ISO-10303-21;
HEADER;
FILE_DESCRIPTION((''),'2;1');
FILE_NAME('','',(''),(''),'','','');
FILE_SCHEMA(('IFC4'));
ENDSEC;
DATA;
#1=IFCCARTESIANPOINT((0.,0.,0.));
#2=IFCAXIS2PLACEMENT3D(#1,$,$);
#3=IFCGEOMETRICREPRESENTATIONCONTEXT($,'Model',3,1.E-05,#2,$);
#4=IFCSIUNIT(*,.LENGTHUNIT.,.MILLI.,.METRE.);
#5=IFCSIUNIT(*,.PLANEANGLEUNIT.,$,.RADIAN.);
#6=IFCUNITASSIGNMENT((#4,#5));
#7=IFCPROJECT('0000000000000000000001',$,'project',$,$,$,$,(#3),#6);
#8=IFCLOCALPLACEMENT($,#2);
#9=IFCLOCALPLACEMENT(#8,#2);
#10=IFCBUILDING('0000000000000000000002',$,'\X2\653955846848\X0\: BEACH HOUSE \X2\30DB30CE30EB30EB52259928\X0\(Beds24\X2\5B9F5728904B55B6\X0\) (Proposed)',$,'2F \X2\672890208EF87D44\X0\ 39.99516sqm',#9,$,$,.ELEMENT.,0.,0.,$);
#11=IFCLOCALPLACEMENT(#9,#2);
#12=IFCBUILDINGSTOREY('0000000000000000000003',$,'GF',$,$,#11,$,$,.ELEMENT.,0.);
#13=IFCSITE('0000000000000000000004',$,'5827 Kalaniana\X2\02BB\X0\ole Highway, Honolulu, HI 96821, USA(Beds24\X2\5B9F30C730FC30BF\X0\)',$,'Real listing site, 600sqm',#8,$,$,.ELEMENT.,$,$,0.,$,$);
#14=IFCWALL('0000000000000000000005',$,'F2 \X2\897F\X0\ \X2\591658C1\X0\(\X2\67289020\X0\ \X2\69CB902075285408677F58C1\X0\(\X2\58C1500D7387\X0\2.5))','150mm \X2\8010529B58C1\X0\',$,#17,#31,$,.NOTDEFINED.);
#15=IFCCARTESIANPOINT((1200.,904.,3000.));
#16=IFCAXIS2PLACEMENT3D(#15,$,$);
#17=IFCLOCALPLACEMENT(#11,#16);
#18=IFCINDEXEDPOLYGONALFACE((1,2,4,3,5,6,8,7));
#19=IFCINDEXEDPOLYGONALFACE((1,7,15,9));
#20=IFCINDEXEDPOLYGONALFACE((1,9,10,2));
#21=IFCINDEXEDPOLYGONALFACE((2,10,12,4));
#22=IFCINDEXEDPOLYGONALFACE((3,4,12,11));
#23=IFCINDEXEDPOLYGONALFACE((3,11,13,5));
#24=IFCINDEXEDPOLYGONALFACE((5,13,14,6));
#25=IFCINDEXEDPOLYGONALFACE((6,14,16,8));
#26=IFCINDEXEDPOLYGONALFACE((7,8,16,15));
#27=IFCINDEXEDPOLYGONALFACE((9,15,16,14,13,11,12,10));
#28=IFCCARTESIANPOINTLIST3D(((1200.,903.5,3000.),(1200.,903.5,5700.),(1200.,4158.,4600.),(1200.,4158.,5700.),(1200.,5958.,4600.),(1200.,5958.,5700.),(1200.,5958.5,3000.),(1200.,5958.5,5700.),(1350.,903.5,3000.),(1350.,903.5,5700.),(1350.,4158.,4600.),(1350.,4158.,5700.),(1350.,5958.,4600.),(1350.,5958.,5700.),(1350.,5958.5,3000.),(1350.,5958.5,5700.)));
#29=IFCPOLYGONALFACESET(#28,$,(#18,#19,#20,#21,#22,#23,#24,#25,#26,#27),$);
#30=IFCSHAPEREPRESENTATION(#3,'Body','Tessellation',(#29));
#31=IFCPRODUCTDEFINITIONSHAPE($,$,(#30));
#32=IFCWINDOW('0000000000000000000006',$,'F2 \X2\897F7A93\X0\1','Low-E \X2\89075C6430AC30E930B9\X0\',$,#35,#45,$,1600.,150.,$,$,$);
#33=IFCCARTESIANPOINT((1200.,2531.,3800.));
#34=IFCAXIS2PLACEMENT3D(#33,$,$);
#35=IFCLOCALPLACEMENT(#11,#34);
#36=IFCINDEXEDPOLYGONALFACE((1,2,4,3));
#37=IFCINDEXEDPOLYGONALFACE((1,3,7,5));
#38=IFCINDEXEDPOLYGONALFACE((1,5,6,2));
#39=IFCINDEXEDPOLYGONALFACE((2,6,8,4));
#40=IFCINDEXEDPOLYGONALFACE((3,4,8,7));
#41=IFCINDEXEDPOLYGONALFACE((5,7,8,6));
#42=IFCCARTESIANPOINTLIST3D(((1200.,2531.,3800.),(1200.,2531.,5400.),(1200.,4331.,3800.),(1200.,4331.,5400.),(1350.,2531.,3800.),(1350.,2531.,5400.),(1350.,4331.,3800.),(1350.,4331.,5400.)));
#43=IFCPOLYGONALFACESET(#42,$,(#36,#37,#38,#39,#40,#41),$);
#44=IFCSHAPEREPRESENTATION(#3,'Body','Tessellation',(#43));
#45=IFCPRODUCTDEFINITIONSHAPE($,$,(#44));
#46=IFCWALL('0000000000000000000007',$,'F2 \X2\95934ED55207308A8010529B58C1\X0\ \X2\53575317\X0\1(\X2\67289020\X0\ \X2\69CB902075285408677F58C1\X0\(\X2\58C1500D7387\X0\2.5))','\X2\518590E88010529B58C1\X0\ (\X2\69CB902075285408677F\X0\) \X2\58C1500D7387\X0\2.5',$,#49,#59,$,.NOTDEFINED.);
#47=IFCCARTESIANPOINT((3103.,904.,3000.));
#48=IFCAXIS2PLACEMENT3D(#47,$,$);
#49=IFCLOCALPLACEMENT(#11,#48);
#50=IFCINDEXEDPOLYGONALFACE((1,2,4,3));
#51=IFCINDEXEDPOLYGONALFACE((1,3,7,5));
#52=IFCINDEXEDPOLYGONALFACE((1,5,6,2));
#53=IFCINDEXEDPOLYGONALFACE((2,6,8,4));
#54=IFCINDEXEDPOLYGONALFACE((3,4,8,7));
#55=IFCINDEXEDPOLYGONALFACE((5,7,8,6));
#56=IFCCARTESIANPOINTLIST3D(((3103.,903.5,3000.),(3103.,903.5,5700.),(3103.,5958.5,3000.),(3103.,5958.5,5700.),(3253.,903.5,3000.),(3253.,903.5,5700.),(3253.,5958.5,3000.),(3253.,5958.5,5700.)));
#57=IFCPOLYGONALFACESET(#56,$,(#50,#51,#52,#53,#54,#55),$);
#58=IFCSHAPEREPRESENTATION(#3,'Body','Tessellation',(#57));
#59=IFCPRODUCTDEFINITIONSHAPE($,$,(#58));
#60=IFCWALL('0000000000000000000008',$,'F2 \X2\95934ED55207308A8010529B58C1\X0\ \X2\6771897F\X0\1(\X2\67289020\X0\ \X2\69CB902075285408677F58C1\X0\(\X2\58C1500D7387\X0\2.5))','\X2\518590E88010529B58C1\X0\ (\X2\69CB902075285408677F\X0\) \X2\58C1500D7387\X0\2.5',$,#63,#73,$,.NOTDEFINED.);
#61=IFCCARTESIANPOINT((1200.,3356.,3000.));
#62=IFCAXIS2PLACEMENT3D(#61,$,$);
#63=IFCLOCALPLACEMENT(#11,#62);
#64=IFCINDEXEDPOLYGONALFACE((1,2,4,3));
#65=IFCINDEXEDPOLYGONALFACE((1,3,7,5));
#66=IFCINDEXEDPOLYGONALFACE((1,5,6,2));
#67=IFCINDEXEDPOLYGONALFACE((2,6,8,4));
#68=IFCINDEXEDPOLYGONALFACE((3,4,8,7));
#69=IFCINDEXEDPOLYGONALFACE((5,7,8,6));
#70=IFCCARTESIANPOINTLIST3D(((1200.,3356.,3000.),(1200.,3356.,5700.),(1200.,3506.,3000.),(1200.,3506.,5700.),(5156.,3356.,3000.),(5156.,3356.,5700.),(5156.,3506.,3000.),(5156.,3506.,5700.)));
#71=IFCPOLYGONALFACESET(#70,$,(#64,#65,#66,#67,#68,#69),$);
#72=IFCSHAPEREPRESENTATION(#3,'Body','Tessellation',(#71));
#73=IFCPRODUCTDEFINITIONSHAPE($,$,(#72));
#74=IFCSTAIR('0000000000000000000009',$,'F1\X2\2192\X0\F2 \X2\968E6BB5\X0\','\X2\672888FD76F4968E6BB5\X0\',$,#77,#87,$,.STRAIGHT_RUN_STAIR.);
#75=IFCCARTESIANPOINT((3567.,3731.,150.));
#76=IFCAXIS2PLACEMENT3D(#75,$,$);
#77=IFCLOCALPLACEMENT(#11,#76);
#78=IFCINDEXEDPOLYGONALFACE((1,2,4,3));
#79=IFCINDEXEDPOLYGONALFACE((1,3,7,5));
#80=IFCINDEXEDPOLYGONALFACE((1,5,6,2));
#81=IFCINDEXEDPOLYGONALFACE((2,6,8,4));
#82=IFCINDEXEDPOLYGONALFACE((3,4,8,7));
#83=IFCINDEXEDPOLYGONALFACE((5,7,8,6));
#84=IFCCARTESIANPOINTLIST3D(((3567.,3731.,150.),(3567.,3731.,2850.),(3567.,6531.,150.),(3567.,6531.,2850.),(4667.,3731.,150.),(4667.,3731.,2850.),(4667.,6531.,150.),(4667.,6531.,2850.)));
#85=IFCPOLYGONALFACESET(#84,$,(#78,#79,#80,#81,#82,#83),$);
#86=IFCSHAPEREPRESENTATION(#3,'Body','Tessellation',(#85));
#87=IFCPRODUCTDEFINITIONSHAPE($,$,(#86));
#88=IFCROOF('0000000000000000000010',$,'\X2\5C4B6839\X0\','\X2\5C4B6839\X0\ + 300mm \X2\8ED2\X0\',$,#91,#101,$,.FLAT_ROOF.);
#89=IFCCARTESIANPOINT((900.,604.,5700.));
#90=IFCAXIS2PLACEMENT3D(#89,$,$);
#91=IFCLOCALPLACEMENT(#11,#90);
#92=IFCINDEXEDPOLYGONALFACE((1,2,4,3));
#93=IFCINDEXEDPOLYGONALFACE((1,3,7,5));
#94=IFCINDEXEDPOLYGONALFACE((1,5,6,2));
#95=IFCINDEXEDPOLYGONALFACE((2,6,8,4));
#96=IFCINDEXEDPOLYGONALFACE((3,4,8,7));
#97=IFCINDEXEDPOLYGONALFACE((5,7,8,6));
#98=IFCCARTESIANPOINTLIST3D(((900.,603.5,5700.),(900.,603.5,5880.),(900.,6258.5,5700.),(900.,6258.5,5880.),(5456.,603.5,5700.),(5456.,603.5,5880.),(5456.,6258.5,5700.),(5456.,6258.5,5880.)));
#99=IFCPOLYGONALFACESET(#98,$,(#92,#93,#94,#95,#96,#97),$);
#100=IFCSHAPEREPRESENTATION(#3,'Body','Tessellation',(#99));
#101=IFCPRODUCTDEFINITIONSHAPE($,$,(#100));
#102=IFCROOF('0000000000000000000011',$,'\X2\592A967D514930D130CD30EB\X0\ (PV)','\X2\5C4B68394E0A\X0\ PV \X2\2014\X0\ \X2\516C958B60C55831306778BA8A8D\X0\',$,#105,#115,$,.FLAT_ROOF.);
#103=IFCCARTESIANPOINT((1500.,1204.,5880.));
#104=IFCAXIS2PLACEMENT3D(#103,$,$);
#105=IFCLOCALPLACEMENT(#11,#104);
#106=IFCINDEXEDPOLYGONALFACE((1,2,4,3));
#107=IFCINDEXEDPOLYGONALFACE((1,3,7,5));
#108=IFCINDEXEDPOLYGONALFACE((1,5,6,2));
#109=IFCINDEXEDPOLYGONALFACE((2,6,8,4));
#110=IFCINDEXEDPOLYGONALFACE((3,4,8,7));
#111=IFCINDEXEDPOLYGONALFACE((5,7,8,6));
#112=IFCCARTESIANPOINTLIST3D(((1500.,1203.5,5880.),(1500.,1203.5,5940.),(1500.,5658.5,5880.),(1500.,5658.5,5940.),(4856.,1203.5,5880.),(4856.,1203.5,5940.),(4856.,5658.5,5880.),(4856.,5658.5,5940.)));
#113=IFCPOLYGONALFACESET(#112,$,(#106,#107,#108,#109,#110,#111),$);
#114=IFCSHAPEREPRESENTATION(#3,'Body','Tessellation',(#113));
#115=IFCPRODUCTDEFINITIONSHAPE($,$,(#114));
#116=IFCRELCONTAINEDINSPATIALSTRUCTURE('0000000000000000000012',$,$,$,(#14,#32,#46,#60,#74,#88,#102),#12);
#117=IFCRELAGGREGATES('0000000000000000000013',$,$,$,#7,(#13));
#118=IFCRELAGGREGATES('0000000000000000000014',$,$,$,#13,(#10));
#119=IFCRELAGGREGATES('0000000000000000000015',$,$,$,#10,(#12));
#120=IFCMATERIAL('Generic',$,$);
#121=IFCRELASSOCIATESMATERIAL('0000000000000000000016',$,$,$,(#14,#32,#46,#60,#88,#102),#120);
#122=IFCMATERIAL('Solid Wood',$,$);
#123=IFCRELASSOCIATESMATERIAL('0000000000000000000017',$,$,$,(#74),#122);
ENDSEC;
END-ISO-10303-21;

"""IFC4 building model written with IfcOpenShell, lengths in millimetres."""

from ifc_helpers import new_model, si_unit, frame, frame_2d, origin, place, context, project, spatial, rectangle, extrude, material, element, fill, save


model = new_model("IFC4")

# Units and contexts
model_context = context("Model", 3, precision=1e-05, world=origin())
ifc_project = project(units=[si_unit("LENGTHUNIT", "METRE", prefix="MILLI"), si_unit("PLANEANGLEUNIT", "RADIAN")], contexts=[model_context])

# Site, building, storey
site_placement = place(None, origin())
site = spatial("IfcSite", under=ifc_project, at=site_placement, Name="5827 Kalanianaʻole Highway, Honolulu, HI 96821, USA(Beds24実データ)", ObjectType="Real listing site, 600sqm", CompositionType="ELEMENT", RefElevation=0.0)
building_placement = place(site_placement, origin())
building = spatial("IfcBuilding", under=site, at=building_placement, Name="改善案: BEACH HOUSE ホノルル別館(Beds24実在運営) (Proposed)", ObjectType="2F 木造軸組 39.99516sqm", CompositionType="ELEMENT", ElevationOfRefHeight=0.0, ElevationOfTerrain=0.0)
storey_placement = place(building_placement, origin())
storey = spatial("IfcBuildingStorey", under=building, at=storey_placement, Name="GF", CompositionType="ELEMENT", Elevation=0.0)

# Shared definitions
ifc_material_1 = material(Name="Generic")

# Shared definitions
ifc_material_2 = material(Name="Solid Wood")

# Wall, opening, window
wall_1_placement = place(storey_placement, frame((1200.0, 904.0, 3000.0)))
wall_1 = element("IfcWall", 1, at=wall_1_placement, inside=storey, material=ifc_material_1, Name="F2 西 外壁(木造 構造用合板壁(壁倍率2.5))", Description="150mm 耐力壁", PredefinedType="NOTDEFINED", context=model_context, shape_type="SweptSolid", body=[
    extrude(rectangle(XDim=150.0, YDim=5055.0, at=frame_2d((75.0, 2527.0))), frame((1200.0, 904.0, 3000.0)), (0.0, 0.0, 1.0), 2700.0),
])
opening_1_placement = place(storey_placement, frame((1200.0, 2531.0, 3800.0)))
opening_1 = element("IfcOpeningElement", 2, at=opening_1_placement, cuts=wall_1, PredefinedType="NOTDEFINED", context=model_context, shape_type="SweptSolid", body=[
    extrude(rectangle(XDim=150.0, YDim=1800.0, at=frame_2d((75.0, 900.0))), frame((1200.0, 2531.0, 3800.0)), (0.0, 0.0, 1.0), 1600.0),
])
window_1_placement = place(storey_placement, frame((1200.0, 2531.0, 3800.0)))
window_1 = element("IfcWindow", 3, at=window_1_placement, inside=storey, material=ifc_material_1, Name="F2 西窓1", Description="Low-E 複層ガラス", OverallHeight=1600.0, OverallWidth=150.0, context=model_context, shape_type="SweptSolid", body=[
    extrude(rectangle(XDim=150.0, YDim=1800.0, at=frame_2d((75.0, 900.0))), frame((1200.0, 2531.0, 3800.0)), (0.0, 0.0, 1.0), 1600.0),
])
fill(opening_1, window_1)

# Walls
wall_2_placement = place(storey_placement, frame((3103.0, 904.0, 3000.0)))
element("IfcWall", 4, at=wall_2_placement, inside=storey, material=ifc_material_1, Name="F2 間仕切り耐力壁 南北1(木造 構造用合板壁(壁倍率2.5))", Description="内部耐力壁 (構造用合板) 壁倍率2.5", PredefinedType="NOTDEFINED", context=model_context, shape_type="SweptSolid", body=[
    extrude(rectangle(XDim=150.0, YDim=5055.0, at=frame_2d((75.0, 2527.0))), frame((3103.0, 904.0, 3000.0)), (0.0, 0.0, 1.0), 2700.0),
])
wall_3_placement = place(storey_placement, frame((1200.0, 3356.0, 3000.0)))
element("IfcWall", 5, at=wall_3_placement, inside=storey, material=ifc_material_1, Name="F2 間仕切り耐力壁 東西1(木造 構造用合板壁(壁倍率2.5))", Description="内部耐力壁 (構造用合板) 壁倍率2.5", PredefinedType="NOTDEFINED", context=model_context, shape_type="SweptSolid", body=[
    extrude(rectangle(XDim=3956.0, YDim=150.0, at=frame_2d((1978.0, 75.0))), frame((1200.0, 3356.0, 3000.0)), (0.0, 0.0, 1.0), 2700.0),
])

# Stair
stair_placement = place(storey_placement, frame((3567.0, 3731.0, 150.0)))
element("IfcStair", 6, at=stair_placement, inside=storey, material=ifc_material_2, Name="F1→F2 階段", Description="木製直階段", PredefinedType="STRAIGHT_RUN_STAIR", context=model_context, shape_type="SweptSolid", body=[
    extrude(rectangle(XDim=1100.0, YDim=2800.0, at=frame_2d((550.0, 1400.0))), frame((3567.0, 3731.0, 150.0)), (0.0, 0.0, 1.0), 2700.0),
])

# Roofs
roof_1_placement = place(storey_placement, frame((900.0, 604.0, 5700.0)))
element("IfcRoof", 7, at=roof_1_placement, inside=storey, material=ifc_material_1, Name="屋根", Description="屋根 + 300mm 軒", PredefinedType="FLAT_ROOF", context=model_context, shape_type="SweptSolid", body=[
    extrude(rectangle(XDim=4556.0, YDim=5655.0, at=frame_2d((2278.0, 2827.0))), frame((900.0, 604.0, 5700.0)), (0.0, 0.0, 1.0), 180.0),
])
roof_2_placement = place(storey_placement, frame((1500.0, 1204.0, 5880.0)))
element("IfcRoof", 8, at=roof_2_placement, inside=storey, material=ifc_material_1, Name="太陽光パネル (PV)", Description="屋根上 PV — 公開情報で確認", PredefinedType="FLAT_ROOF", context=model_context, shape_type="SweptSolid", body=[
    extrude(rectangle(XDim=3356.0, YDim=4455.0, at=frame_2d((1678.0, 2227.0))), frame((1500.0, 1204.0, 5880.0)), (0.0, 0.0, 1.0), 60.0),
])

save(model, "model.ifc")
